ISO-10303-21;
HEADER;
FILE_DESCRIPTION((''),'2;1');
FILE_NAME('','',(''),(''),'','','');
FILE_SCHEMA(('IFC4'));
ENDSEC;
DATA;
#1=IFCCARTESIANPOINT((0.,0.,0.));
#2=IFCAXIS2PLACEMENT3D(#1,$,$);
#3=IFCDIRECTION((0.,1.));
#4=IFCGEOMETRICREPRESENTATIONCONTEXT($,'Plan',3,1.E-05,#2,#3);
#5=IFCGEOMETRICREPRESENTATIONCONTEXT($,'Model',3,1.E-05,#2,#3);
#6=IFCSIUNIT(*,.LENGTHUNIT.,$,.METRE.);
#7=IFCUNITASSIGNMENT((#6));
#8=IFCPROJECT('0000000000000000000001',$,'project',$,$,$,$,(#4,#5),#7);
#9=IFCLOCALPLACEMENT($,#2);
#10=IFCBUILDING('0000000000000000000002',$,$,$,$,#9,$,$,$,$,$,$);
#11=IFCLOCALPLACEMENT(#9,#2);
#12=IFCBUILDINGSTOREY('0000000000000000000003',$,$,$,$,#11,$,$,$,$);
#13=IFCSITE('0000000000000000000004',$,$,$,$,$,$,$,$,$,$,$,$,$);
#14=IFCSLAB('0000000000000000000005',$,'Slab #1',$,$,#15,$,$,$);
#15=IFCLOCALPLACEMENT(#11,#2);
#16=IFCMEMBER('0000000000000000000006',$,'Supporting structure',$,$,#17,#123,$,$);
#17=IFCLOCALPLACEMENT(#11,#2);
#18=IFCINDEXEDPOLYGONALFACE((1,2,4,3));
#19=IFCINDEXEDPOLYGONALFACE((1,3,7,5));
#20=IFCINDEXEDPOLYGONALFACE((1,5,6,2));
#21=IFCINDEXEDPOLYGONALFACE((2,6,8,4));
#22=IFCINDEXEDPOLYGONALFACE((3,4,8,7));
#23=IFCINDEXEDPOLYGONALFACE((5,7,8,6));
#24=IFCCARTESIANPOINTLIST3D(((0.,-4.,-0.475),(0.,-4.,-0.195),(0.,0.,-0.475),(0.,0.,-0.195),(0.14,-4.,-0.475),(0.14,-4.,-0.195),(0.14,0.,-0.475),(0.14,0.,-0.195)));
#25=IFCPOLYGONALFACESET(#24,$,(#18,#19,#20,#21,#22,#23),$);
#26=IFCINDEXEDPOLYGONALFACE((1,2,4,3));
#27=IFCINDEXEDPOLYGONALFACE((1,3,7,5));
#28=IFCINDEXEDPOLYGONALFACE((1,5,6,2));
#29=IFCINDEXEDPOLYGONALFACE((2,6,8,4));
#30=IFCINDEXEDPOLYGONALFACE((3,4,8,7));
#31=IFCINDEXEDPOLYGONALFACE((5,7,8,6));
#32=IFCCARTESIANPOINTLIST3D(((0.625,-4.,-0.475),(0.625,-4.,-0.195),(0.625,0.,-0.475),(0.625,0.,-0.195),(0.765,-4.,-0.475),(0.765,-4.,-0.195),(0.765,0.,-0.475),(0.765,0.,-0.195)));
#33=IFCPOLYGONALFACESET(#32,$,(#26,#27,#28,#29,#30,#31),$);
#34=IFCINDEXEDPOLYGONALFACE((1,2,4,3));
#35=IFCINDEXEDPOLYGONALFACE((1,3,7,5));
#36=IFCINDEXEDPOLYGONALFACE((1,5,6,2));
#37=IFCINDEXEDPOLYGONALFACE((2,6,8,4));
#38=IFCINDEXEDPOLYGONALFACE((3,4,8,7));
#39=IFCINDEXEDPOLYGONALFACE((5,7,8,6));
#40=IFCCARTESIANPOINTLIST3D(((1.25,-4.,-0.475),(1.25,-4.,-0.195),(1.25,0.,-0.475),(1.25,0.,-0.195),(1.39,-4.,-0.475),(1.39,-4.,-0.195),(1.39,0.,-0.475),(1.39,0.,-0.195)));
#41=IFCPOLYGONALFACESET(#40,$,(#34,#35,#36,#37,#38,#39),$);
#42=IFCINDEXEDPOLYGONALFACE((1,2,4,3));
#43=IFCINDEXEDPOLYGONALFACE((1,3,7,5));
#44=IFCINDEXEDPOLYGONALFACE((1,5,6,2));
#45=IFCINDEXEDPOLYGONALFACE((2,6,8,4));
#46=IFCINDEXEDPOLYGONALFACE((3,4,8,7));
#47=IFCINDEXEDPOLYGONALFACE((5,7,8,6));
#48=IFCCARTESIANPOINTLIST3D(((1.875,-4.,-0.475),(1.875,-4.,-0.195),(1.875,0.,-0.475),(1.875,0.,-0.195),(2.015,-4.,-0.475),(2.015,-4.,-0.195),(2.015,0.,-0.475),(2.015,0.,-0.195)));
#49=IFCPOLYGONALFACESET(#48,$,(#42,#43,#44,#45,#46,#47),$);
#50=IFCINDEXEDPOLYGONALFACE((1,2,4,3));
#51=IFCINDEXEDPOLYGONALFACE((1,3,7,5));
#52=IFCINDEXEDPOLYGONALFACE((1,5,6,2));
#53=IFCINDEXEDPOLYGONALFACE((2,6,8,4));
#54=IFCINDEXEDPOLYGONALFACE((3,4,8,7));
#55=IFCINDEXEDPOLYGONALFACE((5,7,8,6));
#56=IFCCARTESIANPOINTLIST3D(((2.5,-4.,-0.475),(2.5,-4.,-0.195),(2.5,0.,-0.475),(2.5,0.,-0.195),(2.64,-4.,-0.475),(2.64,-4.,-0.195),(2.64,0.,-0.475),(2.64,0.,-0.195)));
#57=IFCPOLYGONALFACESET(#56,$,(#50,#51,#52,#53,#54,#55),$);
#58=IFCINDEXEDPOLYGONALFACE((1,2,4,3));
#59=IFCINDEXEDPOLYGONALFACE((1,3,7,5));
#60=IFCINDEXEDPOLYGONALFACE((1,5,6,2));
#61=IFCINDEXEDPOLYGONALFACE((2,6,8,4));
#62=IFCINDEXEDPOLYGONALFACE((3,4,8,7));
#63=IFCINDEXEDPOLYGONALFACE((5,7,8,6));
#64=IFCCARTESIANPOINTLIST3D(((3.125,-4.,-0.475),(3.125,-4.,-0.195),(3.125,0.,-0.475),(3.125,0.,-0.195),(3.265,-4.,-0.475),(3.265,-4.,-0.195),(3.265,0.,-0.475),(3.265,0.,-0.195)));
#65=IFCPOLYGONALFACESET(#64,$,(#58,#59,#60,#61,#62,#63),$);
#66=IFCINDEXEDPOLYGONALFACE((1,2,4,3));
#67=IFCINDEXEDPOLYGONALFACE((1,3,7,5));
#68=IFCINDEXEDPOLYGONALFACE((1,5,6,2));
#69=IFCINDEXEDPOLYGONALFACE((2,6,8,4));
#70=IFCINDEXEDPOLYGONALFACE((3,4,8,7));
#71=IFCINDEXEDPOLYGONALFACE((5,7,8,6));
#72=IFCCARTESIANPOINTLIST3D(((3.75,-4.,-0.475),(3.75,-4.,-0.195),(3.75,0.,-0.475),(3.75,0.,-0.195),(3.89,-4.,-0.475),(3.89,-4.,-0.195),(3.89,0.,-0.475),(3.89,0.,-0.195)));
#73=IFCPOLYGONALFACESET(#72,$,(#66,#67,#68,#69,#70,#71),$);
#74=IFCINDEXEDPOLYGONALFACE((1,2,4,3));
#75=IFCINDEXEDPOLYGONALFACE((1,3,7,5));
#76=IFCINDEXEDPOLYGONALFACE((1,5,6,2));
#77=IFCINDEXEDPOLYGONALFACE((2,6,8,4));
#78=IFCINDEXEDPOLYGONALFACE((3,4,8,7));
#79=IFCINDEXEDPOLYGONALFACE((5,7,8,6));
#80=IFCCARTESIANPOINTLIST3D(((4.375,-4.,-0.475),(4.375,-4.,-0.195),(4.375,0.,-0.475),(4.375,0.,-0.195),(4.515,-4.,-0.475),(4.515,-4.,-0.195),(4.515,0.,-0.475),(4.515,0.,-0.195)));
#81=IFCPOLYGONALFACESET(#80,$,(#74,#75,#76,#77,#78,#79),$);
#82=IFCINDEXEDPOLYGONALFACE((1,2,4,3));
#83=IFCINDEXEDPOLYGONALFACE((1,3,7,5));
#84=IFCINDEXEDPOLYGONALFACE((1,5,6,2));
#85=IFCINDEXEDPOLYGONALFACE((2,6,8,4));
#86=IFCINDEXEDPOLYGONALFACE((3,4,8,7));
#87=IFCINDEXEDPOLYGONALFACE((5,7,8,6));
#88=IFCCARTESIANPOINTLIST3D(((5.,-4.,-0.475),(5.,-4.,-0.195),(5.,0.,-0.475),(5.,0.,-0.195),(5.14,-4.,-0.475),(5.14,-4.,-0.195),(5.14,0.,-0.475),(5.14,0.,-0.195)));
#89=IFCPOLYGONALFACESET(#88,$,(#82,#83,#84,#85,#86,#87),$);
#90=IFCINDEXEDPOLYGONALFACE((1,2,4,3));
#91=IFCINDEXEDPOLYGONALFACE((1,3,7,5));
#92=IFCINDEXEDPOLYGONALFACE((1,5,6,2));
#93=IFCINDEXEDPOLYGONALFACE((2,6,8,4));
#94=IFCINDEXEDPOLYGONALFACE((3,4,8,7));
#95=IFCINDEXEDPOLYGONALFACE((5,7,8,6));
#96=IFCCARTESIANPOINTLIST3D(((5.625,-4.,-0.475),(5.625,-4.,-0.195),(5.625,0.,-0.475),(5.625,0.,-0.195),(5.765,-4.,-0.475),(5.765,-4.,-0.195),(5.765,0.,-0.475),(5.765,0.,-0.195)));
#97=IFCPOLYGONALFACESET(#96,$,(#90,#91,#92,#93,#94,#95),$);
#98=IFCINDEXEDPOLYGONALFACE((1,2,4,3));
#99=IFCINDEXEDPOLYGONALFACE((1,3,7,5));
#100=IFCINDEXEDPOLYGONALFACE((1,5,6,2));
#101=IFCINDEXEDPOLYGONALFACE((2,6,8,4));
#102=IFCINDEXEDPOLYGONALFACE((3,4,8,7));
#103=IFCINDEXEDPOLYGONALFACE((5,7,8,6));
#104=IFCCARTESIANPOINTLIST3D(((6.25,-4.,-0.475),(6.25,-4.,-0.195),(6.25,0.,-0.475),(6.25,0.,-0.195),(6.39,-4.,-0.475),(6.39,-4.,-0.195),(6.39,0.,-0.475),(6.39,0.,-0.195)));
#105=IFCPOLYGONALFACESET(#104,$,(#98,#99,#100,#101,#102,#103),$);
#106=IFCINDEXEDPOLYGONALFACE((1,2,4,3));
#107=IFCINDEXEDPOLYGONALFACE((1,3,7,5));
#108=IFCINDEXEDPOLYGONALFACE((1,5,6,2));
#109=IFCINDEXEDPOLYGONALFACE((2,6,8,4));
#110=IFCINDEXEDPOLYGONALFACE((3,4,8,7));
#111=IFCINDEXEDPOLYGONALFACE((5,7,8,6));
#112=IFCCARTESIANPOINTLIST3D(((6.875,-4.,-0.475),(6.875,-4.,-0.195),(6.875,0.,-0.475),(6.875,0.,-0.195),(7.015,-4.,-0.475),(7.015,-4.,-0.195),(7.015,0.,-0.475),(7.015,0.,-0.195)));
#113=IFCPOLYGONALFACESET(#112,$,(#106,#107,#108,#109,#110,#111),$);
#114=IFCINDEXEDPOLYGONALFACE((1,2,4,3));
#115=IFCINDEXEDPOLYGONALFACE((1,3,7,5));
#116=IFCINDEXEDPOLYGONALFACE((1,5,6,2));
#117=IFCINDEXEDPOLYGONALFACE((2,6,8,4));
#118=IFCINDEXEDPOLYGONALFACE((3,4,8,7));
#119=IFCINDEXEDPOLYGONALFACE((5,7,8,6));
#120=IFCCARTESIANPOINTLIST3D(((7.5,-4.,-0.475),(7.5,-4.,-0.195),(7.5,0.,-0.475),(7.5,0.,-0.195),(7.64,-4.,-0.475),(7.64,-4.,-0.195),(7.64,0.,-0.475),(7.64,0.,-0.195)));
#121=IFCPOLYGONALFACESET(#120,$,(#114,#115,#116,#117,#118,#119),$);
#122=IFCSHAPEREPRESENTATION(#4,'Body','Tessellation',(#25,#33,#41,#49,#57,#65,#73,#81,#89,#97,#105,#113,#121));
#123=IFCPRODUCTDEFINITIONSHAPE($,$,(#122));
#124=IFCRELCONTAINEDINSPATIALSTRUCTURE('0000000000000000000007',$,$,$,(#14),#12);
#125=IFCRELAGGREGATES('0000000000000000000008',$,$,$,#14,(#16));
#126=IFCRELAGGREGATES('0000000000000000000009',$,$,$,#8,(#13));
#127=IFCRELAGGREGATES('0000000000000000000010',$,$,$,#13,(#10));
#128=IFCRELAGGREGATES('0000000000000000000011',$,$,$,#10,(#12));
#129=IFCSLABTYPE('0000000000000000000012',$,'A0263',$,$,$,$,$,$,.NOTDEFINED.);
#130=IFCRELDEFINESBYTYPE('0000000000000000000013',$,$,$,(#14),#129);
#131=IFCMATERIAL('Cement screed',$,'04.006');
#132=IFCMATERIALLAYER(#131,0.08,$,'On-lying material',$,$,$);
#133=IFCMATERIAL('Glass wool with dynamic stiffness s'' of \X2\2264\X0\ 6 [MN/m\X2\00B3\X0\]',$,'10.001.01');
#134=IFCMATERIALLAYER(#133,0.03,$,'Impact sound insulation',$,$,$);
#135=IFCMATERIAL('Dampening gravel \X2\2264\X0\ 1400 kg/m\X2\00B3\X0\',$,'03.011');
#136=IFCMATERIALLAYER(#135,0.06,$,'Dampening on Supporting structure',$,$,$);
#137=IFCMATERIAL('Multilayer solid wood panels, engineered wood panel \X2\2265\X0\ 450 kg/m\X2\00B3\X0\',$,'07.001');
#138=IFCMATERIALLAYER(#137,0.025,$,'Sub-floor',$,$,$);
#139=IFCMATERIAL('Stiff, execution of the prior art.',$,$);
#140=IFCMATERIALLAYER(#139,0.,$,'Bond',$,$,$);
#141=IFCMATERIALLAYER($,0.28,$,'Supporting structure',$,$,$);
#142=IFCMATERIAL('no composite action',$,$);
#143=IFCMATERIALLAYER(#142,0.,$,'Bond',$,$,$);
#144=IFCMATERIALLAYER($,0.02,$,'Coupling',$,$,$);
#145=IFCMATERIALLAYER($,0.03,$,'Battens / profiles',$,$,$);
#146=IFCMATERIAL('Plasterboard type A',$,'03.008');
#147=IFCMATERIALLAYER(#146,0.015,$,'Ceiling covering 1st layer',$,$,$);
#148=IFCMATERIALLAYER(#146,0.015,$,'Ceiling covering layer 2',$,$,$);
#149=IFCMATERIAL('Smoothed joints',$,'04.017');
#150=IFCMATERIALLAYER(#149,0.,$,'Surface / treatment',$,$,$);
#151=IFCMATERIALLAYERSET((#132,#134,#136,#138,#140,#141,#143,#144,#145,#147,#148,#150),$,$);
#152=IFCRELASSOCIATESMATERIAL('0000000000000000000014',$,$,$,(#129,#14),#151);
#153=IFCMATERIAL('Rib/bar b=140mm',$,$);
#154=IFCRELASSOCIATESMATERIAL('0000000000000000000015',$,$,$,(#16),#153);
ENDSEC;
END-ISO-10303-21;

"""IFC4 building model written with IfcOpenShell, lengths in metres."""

from ifc_helpers import new_model, si_unit, direction, frame, frame_2d, origin, place, context, project, spatial, rectangle, extrude, material, layer, layer_set, type_object, element, aggregate, save


model = new_model("IFC4")

# Units and contexts
plan_context = context("Plan", 3, precision=1e-05, world=origin(), true_north=direction((0.0, 1.0)))
model_context = context("Model", 3, precision=1e-05, world=origin(), true_north=direction((0.0, 1.0)))
ifc_project = project(units=[si_unit("LENGTHUNIT", "METRE")], contexts=[plan_context, model_context])

# Site, building, storey
site = spatial("IfcSite", under=ifc_project)
building_placement = place(None, origin())
building = spatial("IfcBuilding", under=site, at=building_placement)
storey_placement = place(building_placement, origin())
storey = spatial("IfcBuildingStorey", under=building, at=storey_placement)

# Slab, member
ifc_material_1 = material(Name="Cement screed", Category="04.006")
ifc_layer_1 = layer(ifc_material_1, 0.08, Name="On-lying material")
ifc_material_2 = material(Name="Glass wool with dynamic stiffness s' of ≤ 6 [MN/m³]", Category="10.001.01")
ifc_layer_2 = layer(ifc_material_2, 0.03, Name="Impact sound insulation")
ifc_material_3 = material(Name="Dampening gravel ≤ 1400 kg/m³", Category="03.011")
ifc_layer_3 = layer(ifc_material_3, 0.06, Name="Dampening on Supporting structure")
ifc_material_4 = material(Name="Multilayer solid wood panels, engineered wood panel ≥ 450 kg/m³", Category="07.001")
ifc_layer_4 = layer(ifc_material_4, 0.025, Name="Sub-floor")
ifc_material_5 = material(Name="Stiff, execution of the prior art.")
ifc_layer_5 = layer(ifc_material_5, 0.0, Name="Bond")
ifc_layer_6 = layer(None, 0.28, Name="Supporting structure")
ifc_material_6 = material(Name="no composite action")
ifc_layer_7 = layer(ifc_material_6, 0.0, Name="Bond")
ifc_layer_8 = layer(None, 0.02, Name="Coupling")
ifc_layer_9 = layer(None, 0.03, Name="Battens / profiles")
ifc_material_7 = material(Name="Plasterboard type A", Category="03.008")
ifc_layer_10 = layer(ifc_material_7, 0.015, Name="Ceiling covering 1st layer")
ifc_layer_11 = layer(ifc_material_7, 0.015, Name="Ceiling covering layer 2")
ifc_material_8 = material(Name="Smoothed joints", Category="04.017")
ifc_layer_12 = layer(ifc_material_8, 0.0, Name="Surface / treatment")
ifc_layer_set = layer_set([ifc_layer_1, ifc_layer_2, ifc_layer_3, ifc_layer_4, ifc_layer_5, ifc_layer_6, ifc_layer_7, ifc_layer_8, ifc_layer_9, ifc_layer_10, ifc_layer_11, ifc_layer_12])
slab_type = type_object("IfcSlabType", Name="A0263", PredefinedType="NOTDEFINED", material=ifc_layer_set)
slab_placement = place(None, frame((0.0, 0.0, 0.0), z_axis=(0.0, 0.0, -1.0), x_axis=(1.0, 0.0, 0.0)))
slab = element("IfcSlab", 1, at=slab_placement, inside=storey, type_object=slab_type, material=ifc_layer_set, Name="Slab #1")
ifc_material_9 = material(Name="Rib/bar b=140mm")
member_1_placement = place(slab_placement, origin())
member_1 = element("IfcMember", 2, at=member_1_placement, material=ifc_material_9, Name="Supporting structure", context=plan_context, shape_type="SweptSolid", body=[
    extrude(rectangle(XDim=0.14, YDim=0.28, at=frame_2d((0.07, 0.14), x_axis=(1.0, 0.0))), frame((0.0, 4.0, 0.195), z_axis=(0.0, -1.0, 0.0), x_axis=(1.0, 0.0, 0.0)), (0.0, 0.0, 1.0), 4.0),
    extrude(rectangle(XDim=0.14, YDim=0.28, at=frame_2d((0.07, 0.14), x_axis=(1.0, 0.0))), frame((0.625, 4.0, 0.195), z_axis=(0.0, -1.0, 0.0), x_axis=(1.0, 0.0, 0.0)), (0.0, 0.0, 1.0), 4.0),
    extrude(rectangle(XDim=0.14, YDim=0.28, at=frame_2d((0.07, 0.14), x_axis=(1.0, 0.0))), frame((1.25, 4.0, 0.195), z_axis=(0.0, -1.0, 0.0), x_axis=(1.0, 0.0, 0.0)), (0.0, 0.0, 1.0), 4.0),
    extrude(rectangle(XDim=0.14, YDim=0.28, at=frame_2d((0.07, 0.14), x_axis=(1.0, 0.0))), frame((1.875, 4.0, 0.195), z_axis=(0.0, -1.0, 0.0), x_axis=(1.0, 0.0, 0.0)), (0.0, 0.0, 1.0), 4.0),
    extrude(rectangle(XDim=0.14, YDim=0.28, at=frame_2d((0.07, 0.14), x_axis=(1.0, 0.0))), frame((2.5, 4.0, 0.195), z_axis=(0.0, -1.0, 0.0), x_axis=(1.0, 0.0, 0.0)), (0.0, 0.0, 1.0), 4.0),
    extrude(rectangle(XDim=0.14, YDim=0.28, at=frame_2d((0.07, 0.14), x_axis=(1.0, 0.0))), frame((3.125, 4.0, 0.195), z_axis=(0.0, -1.0, 0.0), x_axis=(1.0, 0.0, 0.0)), (0.0, 0.0, 1.0), 4.0),
    extrude(rectangle(XDim=0.14, YDim=0.28, at=frame_2d((0.07, 0.14), x_axis=(1.0, 0.0))), frame((3.75, 4.0, 0.195), z_axis=(0.0, -1.0, 0.0), x_axis=(1.0, 0.0, 0.0)), (0.0, 0.0, 1.0), 4.0),
    extrude(rectangle(XDim=0.14, YDim=0.28, at=frame_2d((0.07, 0.14), x_axis=(1.0, 0.0))), frame((4.375, 4.0, 0.195), z_axis=(0.0, -1.0, 0.0), x_axis=(1.0, 0.0, 0.0)), (0.0, 0.0, 1.0), 4.0),
    extrude(rectangle(XDim=0.14, YDim=0.28, at=frame_2d((0.07, 0.14), x_axis=(1.0, 0.0))), frame((5.0, 4.0, 0.195), z_axis=(0.0, -1.0, 0.0), x_axis=(1.0, 0.0, 0.0)), (0.0, 0.0, 1.0), 4.0),
    extrude(rectangle(XDim=0.14, YDim=0.28, at=frame_2d((0.07, 0.14), x_axis=(1.0, 0.0))), frame((5.625, 4.0, 0.195), z_axis=(0.0, -1.0, 0.0), x_axis=(1.0, 0.0, 0.0)), (0.0, 0.0, 1.0), 4.0),
    extrude(rectangle(XDim=0.14, YDim=0.28, at=frame_2d((0.07, 0.14), x_axis=(1.0, 0.0))), frame((6.25, 4.0, 0.195), z_axis=(0.0, -1.0, 0.0), x_axis=(1.0, 0.0, 0.0)), (0.0, 0.0, 1.0), 4.0),
    extrude(rectangle(XDim=0.14, YDim=0.28, at=frame_2d((0.07, 0.14), x_axis=(1.0, 0.0))), frame((6.875, 4.0, 0.195), z_axis=(0.0, -1.0, 0.0), x_axis=(1.0, 0.0, 0.0)), (0.0, 0.0, 1.0), 4.0),
    extrude(rectangle(XDim=0.14, YDim=0.28, at=frame_2d((0.07, 0.14), x_axis=(1.0, 0.0))), frame((7.5, 4.0, 0.195), z_axis=(0.0, -1.0, 0.0), x_axis=(1.0, 0.0, 0.0)), (0.0, 0.0, 1.0), 4.0),
])
aggregate(slab, [member_1])

save(model, "model.ifc")
